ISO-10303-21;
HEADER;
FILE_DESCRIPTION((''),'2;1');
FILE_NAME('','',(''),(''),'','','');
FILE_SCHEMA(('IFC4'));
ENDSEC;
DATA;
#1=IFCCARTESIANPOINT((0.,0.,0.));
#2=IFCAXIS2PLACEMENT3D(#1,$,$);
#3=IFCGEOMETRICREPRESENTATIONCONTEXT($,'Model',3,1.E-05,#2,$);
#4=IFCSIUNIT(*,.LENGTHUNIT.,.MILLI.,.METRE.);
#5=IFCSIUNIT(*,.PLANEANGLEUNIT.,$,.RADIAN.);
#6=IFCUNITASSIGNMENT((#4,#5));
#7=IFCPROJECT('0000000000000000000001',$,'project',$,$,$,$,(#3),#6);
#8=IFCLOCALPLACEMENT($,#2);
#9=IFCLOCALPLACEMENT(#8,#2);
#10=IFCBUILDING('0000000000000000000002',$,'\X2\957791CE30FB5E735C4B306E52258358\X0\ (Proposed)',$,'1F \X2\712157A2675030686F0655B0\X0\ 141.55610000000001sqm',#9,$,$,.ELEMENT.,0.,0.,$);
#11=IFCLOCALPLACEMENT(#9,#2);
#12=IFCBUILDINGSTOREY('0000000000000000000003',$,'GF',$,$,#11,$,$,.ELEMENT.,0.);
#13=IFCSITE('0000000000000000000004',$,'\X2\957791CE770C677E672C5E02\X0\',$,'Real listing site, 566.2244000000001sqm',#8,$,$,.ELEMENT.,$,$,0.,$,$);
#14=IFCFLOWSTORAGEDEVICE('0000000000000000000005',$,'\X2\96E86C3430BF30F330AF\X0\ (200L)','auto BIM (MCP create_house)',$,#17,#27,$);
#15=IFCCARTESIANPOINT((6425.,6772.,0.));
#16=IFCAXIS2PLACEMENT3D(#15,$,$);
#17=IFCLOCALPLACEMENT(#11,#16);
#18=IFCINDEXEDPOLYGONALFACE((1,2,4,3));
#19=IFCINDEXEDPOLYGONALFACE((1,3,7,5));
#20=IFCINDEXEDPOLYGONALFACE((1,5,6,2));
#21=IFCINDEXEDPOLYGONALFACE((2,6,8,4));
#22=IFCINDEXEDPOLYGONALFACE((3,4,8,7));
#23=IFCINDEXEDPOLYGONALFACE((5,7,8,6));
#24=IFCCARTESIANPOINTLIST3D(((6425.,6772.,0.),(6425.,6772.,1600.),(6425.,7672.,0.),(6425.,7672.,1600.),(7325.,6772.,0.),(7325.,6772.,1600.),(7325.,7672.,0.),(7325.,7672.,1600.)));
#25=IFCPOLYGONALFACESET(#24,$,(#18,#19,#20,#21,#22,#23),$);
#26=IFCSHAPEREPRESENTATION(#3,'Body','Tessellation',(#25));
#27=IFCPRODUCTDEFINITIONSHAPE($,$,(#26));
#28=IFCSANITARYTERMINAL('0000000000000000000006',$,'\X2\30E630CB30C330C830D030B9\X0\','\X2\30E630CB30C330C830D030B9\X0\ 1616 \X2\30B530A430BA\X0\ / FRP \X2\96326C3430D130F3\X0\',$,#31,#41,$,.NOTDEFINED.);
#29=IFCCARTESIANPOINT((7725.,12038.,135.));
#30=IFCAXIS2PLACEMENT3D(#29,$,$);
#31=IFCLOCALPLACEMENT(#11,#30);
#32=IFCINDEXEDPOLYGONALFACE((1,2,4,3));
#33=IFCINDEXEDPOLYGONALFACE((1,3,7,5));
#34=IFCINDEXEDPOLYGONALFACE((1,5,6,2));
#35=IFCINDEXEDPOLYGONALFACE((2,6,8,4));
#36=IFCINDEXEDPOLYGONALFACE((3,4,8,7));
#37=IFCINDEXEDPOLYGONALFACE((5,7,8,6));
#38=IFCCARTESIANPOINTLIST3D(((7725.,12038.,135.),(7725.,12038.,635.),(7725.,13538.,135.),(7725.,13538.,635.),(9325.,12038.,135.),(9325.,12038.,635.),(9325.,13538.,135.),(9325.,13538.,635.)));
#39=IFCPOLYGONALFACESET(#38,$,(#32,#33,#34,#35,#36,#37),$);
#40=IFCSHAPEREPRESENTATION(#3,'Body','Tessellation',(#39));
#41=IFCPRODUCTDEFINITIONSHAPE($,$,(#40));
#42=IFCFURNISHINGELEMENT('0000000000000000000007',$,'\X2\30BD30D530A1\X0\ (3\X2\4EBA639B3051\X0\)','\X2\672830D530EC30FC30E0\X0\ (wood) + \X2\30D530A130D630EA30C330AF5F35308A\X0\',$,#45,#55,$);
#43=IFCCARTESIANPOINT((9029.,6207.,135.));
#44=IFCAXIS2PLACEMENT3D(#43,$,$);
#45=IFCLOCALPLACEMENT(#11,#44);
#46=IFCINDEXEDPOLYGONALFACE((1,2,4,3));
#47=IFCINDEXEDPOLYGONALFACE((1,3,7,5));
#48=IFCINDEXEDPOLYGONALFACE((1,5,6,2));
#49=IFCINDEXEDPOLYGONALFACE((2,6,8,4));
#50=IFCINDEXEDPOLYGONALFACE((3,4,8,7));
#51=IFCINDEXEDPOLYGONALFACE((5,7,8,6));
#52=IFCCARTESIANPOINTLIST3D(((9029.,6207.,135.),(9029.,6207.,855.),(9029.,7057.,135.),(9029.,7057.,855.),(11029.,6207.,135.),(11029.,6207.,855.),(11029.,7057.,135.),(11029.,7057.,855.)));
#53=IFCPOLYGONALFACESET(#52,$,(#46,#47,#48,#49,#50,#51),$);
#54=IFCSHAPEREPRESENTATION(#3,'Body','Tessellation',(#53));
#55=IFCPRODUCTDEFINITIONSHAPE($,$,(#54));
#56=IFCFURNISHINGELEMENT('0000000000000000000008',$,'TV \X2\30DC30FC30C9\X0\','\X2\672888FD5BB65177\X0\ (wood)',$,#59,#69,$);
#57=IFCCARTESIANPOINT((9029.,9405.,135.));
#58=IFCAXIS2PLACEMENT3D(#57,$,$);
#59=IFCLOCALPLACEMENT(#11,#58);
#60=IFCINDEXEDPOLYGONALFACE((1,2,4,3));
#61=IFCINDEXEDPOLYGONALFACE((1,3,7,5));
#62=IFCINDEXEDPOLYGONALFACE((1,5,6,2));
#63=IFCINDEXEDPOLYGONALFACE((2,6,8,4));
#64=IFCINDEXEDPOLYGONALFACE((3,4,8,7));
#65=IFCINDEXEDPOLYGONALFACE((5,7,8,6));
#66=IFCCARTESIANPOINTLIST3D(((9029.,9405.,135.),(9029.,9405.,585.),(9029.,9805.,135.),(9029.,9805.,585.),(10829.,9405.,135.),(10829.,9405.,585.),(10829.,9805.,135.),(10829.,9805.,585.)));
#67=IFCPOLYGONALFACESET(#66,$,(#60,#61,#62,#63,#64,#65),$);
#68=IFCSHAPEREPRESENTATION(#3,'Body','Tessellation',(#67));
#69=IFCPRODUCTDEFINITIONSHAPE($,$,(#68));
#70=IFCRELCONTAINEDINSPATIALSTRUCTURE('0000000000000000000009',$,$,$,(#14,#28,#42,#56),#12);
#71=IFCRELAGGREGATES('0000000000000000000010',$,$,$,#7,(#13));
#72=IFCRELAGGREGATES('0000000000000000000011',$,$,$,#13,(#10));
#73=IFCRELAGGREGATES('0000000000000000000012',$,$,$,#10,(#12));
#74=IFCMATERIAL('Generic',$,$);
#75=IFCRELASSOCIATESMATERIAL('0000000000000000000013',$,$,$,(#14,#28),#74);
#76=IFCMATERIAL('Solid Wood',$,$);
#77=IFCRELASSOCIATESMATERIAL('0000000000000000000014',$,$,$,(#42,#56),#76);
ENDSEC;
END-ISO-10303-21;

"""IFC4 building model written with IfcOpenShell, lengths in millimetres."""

from ifc_helpers import new_model, si_unit, frame, frame_2d, origin, place, context, project, spatial, rectangle, extrude, material, element, save


model = new_model("IFC4")

# Units and contexts
model_context = context("Model", 3, precision=1e-05, world=origin())
ifc_project = project(units=[si_unit("LENGTHUNIT", "METRE", prefix="MILLI"), si_unit("PLANEANGLEUNIT", "RADIAN")], contexts=[model_context])

# Site, building, storey
site_placement = place(None, origin())
site = spatial("IfcSite", under=ifc_project, at=site_placement, Name="長野県松本市", ObjectType="Real listing site, 566.2244000000001sqm", CompositionType="ELEMENT", RefElevation=0.0)
building_placement = place(site_placement, origin())
building = spatial("IfcBuilding", under=site, at=building_placement, Name="長野・平屋の別荘 (Proposed)", ObjectType="1F 無垢材と漆喰 141.55610000000001sqm", CompositionType="ELEMENT", ElevationOfRefHeight=0.0, ElevationOfTerrain=0.0)
storey_placement = place(building_placement, origin())
storey = spatial("IfcBuildingStorey", under=building, at=storey_placement, Name="GF", CompositionType="ELEMENT", Elevation=0.0)

# Shared definitions
ifc_material_1 = material(Name="Solid Wood")

# Shared definitions
ifc_material_2 = material(Name="Generic")

# Flow storage device
flow_storage_device_placement = place(storey_placement, frame((6425.0, 6772.0, 0.0)))
element("IfcFlowStorageDevice", 1, at=flow_storage_device_placement, inside=storey, material=ifc_material_2, Name="雨水タンク (200L)", Description="auto BIM (MCP create_house)", context=model_context, shape_type="SweptSolid", body=[
    extrude(rectangle(XDim=900.0, YDim=900.0, at=frame_2d((450.0, 450.0))), frame((6425.0, 6772.0, 0.0)), (0.0, 0.0, 1.0), 1600.0),
])

# Sanitary terminal
sanitary_terminal_placement = place(storey_placement, frame((7725.0, 12038.0, 135.0)))
element("IfcSanitaryTerminal", 2, at=sanitary_terminal_placement, inside=storey, material=ifc_material_2, Name="ユニットバス", Description="ユニットバス 1616 サイズ / FRP 防水パン", PredefinedType="NOTDEFINED", context=model_context, shape_type="SweptSolid", body=[
    extrude(rectangle(XDim=1600.0, YDim=1500.0, at=frame_2d((800.0, 750.0))), frame((7725.0, 12038.0, 135.0)), (0.0, 0.0, 1.0), 500.0),
])

# Furnishing elements
furnishing_1_placement = place(storey_placement, frame((9029.0, 6207.0, 135.0)))
element("IfcFurnishingElement", 3, at=furnishing_1_placement, inside=storey, material=ifc_material_1, Name="ソファ (3人掛け)", Description="木フレーム (wood) + ファブリック張り", context=model_context, shape_type="SweptSolid", body=[
    extrude(rectangle(XDim=2000.0, YDim=850.0, at=frame_2d((1000.0, 425.0))), frame((9029.0, 6207.0, 135.0)), (0.0, 0.0, 1.0), 720.0),
])
furnishing_2_placement = place(storey_placement, frame((9029.0, 9405.0, 135.0)))
element("IfcFurnishingElement", 4, at=furnishing_2_placement, inside=storey, material=ifc_material_1, Name="TV ボード", Description="木製家具 (wood)", context=model_context, shape_type="SweptSolid", body=[
    extrude(rectangle(XDim=1800.0, YDim=400.0, at=frame_2d((900.0, 200.0))), frame((9029.0, 9405.0, 135.0)), (0.0, 0.0, 1.0), 450.0),
])

save(model, "model.ifc")
